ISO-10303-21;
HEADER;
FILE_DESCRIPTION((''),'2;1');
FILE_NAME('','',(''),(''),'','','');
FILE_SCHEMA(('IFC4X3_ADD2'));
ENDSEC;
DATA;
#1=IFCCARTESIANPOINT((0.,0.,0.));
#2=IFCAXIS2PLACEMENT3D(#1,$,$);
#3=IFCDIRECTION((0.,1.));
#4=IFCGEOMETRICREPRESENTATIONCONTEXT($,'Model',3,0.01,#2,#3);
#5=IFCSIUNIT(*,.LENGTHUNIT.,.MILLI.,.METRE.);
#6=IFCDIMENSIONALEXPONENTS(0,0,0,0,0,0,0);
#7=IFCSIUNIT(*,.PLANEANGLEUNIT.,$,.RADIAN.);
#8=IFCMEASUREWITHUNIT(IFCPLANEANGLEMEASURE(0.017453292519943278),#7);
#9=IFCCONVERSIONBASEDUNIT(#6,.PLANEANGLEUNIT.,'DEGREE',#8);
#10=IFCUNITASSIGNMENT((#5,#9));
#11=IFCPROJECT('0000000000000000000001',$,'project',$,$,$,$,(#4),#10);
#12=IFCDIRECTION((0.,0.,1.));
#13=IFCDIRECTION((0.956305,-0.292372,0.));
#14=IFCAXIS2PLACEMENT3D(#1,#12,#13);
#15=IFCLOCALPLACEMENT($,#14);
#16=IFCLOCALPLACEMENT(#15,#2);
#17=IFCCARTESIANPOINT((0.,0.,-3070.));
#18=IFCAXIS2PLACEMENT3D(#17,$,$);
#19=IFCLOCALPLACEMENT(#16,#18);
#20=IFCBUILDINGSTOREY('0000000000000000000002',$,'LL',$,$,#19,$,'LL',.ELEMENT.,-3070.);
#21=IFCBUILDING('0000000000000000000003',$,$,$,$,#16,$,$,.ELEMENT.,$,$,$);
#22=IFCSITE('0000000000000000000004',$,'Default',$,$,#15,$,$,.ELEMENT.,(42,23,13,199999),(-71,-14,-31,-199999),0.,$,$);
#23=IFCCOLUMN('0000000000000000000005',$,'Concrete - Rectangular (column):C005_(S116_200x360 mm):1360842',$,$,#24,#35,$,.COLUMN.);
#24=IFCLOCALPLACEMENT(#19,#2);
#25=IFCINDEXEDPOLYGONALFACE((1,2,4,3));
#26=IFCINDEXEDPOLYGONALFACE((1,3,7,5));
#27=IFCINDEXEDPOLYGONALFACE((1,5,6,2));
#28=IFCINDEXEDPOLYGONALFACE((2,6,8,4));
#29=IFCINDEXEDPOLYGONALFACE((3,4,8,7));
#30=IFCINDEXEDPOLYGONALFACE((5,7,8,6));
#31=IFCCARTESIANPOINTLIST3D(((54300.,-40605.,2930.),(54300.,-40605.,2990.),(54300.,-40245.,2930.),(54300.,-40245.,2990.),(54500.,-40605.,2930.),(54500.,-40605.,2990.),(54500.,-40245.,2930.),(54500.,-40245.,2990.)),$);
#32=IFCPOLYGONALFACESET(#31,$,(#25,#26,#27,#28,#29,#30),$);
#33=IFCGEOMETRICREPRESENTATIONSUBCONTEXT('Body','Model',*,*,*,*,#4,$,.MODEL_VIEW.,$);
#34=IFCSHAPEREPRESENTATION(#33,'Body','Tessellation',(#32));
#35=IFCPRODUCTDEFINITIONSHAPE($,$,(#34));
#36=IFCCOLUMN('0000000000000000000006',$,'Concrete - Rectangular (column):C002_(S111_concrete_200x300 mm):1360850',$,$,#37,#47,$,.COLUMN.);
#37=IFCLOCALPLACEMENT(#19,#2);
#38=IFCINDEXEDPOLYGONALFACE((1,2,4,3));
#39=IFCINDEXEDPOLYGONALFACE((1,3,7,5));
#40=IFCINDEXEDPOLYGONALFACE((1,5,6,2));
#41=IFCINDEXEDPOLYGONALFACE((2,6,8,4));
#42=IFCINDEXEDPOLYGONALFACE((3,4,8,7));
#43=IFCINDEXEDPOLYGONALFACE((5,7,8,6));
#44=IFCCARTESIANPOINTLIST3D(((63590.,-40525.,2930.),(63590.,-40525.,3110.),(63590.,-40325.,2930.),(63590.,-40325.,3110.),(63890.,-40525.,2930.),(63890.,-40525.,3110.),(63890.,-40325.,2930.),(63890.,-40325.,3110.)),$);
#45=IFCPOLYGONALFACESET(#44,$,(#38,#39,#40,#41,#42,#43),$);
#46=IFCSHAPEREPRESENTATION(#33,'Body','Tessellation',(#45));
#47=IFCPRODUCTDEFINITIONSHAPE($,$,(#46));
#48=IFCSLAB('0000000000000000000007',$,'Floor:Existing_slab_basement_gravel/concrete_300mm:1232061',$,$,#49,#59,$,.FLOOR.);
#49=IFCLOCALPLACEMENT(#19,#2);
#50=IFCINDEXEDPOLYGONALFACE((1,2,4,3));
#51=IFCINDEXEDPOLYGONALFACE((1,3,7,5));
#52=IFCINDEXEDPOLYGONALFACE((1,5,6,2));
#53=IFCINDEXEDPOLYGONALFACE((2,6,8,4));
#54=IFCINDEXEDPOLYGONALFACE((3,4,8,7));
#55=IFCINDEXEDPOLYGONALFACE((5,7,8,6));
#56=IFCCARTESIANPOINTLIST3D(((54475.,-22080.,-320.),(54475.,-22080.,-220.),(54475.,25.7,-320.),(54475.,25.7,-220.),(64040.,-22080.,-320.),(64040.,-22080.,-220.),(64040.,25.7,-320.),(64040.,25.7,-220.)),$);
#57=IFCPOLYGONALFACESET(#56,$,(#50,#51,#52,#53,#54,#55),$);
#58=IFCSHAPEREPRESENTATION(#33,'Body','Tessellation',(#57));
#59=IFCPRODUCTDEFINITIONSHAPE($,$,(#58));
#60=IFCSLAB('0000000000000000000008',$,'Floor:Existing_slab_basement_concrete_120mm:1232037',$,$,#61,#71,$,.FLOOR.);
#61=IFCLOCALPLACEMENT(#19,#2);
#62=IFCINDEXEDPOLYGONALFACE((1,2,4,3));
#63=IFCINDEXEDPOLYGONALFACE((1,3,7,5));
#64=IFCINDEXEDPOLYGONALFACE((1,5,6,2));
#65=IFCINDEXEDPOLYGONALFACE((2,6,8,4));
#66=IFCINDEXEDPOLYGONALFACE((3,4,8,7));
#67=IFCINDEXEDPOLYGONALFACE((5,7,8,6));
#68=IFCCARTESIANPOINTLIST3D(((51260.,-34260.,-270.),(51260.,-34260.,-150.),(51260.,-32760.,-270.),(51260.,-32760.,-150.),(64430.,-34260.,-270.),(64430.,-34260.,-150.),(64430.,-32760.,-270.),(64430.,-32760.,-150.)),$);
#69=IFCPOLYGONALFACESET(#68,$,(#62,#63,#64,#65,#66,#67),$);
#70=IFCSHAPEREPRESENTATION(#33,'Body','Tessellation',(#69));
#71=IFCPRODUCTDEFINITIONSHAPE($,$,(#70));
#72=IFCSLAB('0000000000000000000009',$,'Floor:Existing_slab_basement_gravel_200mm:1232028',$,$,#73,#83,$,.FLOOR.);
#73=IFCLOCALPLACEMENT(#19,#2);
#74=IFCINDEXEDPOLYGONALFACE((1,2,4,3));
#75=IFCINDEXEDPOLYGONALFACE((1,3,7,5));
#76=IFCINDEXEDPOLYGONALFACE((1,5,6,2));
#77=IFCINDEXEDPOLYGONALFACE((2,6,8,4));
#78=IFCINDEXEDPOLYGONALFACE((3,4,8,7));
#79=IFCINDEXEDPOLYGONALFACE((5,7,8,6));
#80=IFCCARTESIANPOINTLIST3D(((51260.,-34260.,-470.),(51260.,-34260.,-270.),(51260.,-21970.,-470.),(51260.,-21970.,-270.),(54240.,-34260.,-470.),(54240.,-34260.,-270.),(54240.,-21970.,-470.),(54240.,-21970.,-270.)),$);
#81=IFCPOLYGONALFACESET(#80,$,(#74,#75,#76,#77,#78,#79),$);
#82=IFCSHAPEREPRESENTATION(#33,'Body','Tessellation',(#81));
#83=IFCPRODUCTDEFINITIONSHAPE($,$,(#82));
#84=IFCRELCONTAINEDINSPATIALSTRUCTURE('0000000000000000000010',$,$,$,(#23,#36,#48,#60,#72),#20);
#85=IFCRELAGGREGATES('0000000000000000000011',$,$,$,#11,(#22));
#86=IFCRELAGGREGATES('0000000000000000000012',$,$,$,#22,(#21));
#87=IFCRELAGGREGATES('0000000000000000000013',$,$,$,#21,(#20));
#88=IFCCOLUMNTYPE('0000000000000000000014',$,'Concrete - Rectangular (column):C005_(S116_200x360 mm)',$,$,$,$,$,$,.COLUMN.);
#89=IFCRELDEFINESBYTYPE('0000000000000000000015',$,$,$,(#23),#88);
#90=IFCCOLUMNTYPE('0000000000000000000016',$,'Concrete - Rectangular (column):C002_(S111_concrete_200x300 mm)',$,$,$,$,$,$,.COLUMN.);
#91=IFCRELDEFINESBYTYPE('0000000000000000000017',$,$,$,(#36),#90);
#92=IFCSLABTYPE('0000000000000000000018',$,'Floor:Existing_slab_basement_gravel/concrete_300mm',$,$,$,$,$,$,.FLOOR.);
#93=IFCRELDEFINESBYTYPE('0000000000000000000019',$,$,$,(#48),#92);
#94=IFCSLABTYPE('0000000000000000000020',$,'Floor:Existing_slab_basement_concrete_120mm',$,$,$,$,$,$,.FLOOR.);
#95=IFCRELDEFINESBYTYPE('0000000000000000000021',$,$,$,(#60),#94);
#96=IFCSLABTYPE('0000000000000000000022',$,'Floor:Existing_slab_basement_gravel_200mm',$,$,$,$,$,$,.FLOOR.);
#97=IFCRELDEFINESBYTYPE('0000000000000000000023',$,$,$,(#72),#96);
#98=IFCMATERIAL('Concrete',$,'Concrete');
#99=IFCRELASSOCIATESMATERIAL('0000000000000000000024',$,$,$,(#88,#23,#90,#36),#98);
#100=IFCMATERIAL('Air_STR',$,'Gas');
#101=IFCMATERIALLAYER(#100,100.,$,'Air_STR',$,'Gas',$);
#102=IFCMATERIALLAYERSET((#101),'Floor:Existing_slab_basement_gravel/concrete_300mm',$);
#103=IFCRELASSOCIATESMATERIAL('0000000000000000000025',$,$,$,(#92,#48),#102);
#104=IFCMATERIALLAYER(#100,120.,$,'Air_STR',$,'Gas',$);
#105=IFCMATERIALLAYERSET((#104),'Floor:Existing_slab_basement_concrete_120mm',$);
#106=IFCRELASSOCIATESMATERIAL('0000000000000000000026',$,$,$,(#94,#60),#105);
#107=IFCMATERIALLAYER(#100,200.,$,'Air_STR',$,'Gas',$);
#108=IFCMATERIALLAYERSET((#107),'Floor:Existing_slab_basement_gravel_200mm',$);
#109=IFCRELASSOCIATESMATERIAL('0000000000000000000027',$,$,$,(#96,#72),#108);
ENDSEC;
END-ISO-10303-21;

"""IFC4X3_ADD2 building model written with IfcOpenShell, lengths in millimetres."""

from ifc_helpers import new_model, entity, si_unit, converted_unit, direction, frame, frame_2d, origin, place, context, subcontext, project, spatial, rectangle, extrude, source, transform, mapped, material, layer, layer_set, layer_usage, material_profile, profile_set, profile_usage, type_object, type_shapes, element, save


model = new_model("IFC4X3_ADD2")

# Units and contexts
model_context = context("Model", 3, precision=0.01, world=origin(), true_north=direction((0.0, 1.0)))
body_context = subcontext(model_context, "Body", "Model", "MODEL_VIEW")
ifc_project = project(units=[si_unit("LENGTHUNIT", "METRE", prefix="MILLI"), converted_unit("PLANEANGLEUNIT", "DEGREE", entity("IfcPlaneAngleMeasure", 0.017453292519943278), si_unit("PLANEANGLEUNIT", "RADIAN"), dimensions=[0, 0, 0, 0, 0, 0, 0])], contexts=[model_context])

# Site, building, storey
site_placement = place(None, frame((0.0, 0.0, 0.0), z_axis=(0.0, 0.0, 1.0), x_axis=(0.956305, -0.292372, 0.0)))
site = spatial("IfcSite", under=ifc_project, at=site_placement, Name="Default", CompositionType="ELEMENT", RefLatitude=(42, 23, 13, 199999), RefLongitude=(-71, -14, -31, -199999), RefElevation=0.0)
building_placement = place(site_placement, origin())
building = spatial("IfcBuilding", under=site, at=building_placement, CompositionType="ELEMENT")
storey_placement = place(building_placement, frame((0.0, 0.0, -3070.0)))
storey = spatial("IfcBuildingStorey", under=building, at=storey_placement, Name="LL", LongName="LL", CompositionType="ELEMENT", Elevation=-3070.0)

# Columns
ifc_material_1 = material(Name="Concrete", Category="Concrete")
ifc_material_profile_1 = material_profile(ifc_material_1, rectangle(XDim=300.0, YDim=200.0, at=frame_2d((0.0, 0.0), x_axis=(1.0, 0.0))), Name="C002_(S111_concrete_200x300 mm)")
ifc_profile_set_1 = profile_set([ifc_material_profile_1], Name="C002_(S111_concrete_200x300 mm)")
ifc_profile_usage_1 = profile_usage(ifc_profile_set_1)
ifc_material_profile_2 = material_profile(ifc_material_1, rectangle(XDim=200.0, YDim=360.0, at=frame_2d((0.0, 0.0), x_axis=(1.0, 0.0))), Name="C005_(S116_200x360 mm)")
ifc_profile_set_2 = profile_set([ifc_material_profile_2], Name="C005_(S116_200x360 mm)")
ifc_profile_usage_2 = profile_usage(ifc_profile_set_2)
column_type_1 = type_object("IfcColumnType", Name="Concrete - Rectangular (column):C005_(S116_200x360 mm)", PredefinedType="COLUMN", material=ifc_profile_set_2)
shared_shape_1 = source(origin(), body_context, "Body", "SweptSolid", [
    extrude(rectangle(XDim=200.0, YDim=360.0, at=frame_2d((0.0, 0.0), x_axis=(1.0, 0.0))), frame((54400.0, -40425.0, -140.0), z_axis=(0.0, 0.0, 1.0), x_axis=(-1.0, 0.0, 0.0)), (0.0, 0.0, 1.0), 60.0),
])
type_shapes(column_type_1, [shared_shape_1])
column_1_placement = place(storey_placement, frame((0.0, 0.0, 3070.0)))
element("IfcColumn", 1, at=column_1_placement, inside=storey, type_object=column_type_1, material=ifc_profile_usage_2, Name="Concrete - Rectangular (column):C005_(S116_200x360 mm):1360842", PredefinedType="COLUMN", context=body_context, shape_type="MappedRepresentation", body=[
    mapped(shared_shape_1, transform((0.0, 0.0, 0.0), scale=1.0)),
])
column_type_2 = type_object("IfcColumnType", Name="Concrete - Rectangular (column):C002_(S111_concrete_200x300 mm)", PredefinedType="COLUMN", material=ifc_profile_set_1)
shared_shape_2 = source(origin(), body_context, "Body", "SweptSolid", [
    extrude(rectangle(XDim=300.0, YDim=200.0, at=frame_2d((0.0, 0.0), x_axis=(1.0, 0.0))), frame((63740.0, -40425.0, -140.0), z_axis=(0.0, 0.0, 1.0), x_axis=(-1.0, 0.0, 0.0)), (0.0, 0.0, 1.0), 180.0),
])
type_shapes(column_type_2, [shared_shape_2])
column_2_placement = place(storey_placement, frame((0.0, 0.0, 3070.0)))
element("IfcColumn", 2, at=column_2_placement, inside=storey, type_object=column_type_2, material=ifc_profile_usage_1, Name="Concrete - Rectangular (column):C002_(S111_concrete_200x300 mm):1360850", PredefinedType="COLUMN", context=body_context, shape_type="MappedRepresentation", body=[
    mapped(shared_shape_2, transform((0.0, 0.0, 0.0), scale=1.0)),
])

# Slabs
ifc_material_2 = material(Name="Air_STR", Category="Gas")
ifc_layer_1 = layer(ifc_material_2, 100.0, Name="Air_STR", Category="Gas")
ifc_layer_set_1 = layer_set([ifc_layer_1], Name="Floor:Existing_slab_basement_gravel/concrete_300mm")
ifc_layer_usage_1 = layer_usage(ifc_layer_set_1, "AXIS3", "POSITIVE", 0.0)
slab_type_1 = type_object("IfcSlabType", Name="Floor:Existing_slab_basement_gravel/concrete_300mm", PredefinedType="FLOOR", material=ifc_layer_set_1)
slab_1_placement = place(storey_placement, origin())
element("IfcSlab", 3, at=slab_1_placement, inside=storey, type_object=slab_type_1, material=ifc_layer_usage_1, Name="Floor:Existing_slab_basement_gravel/concrete_300mm:1232061", PredefinedType="FLOOR", context=body_context, shape_type="SweptSolid", body=[
    extrude(rectangle(XDim=22105.7, YDim=9565.0, at=frame_2d((0.0, 0.0), x_axis=(1.0, 0.0))), frame((59257.5, -11027.1, -220.0), z_axis=(0.0, 0.0, -1.0), x_axis=(0.0, 1.0, 0.0)), (0.0, 0.0, 1.0), 100.0),
])
ifc_layer_2 = layer(ifc_material_2, 120.0, Name="Air_STR", Category="Gas")
ifc_layer_set_2 = layer_set([ifc_layer_2], Name="Floor:Existing_slab_basement_concrete_120mm")
ifc_layer_usage_2 = layer_usage(ifc_layer_set_2, "AXIS3", "POSITIVE", 0.0)
slab_type_2 = type_object("IfcSlabType", Name="Floor:Existing_slab_basement_concrete_120mm", PredefinedType="FLOOR", material=ifc_layer_set_2)
slab_2_placement = place(storey_placement, origin())
element("IfcSlab", 4, at=slab_2_placement, inside=storey, type_object=slab_type_2, material=ifc_layer_usage_2, Name="Floor:Existing_slab_basement_concrete_120mm:1232037", PredefinedType="FLOOR", context=body_context, shape_type="SweptSolid", body=[
    extrude(rectangle(XDim=1500.0, YDim=13170.0, at=frame_2d((0.0, 0.0), x_axis=(1.0, 0.0))), frame((57845.0, -33510.0, -150.0), z_axis=(0.0, 0.0, -1.0), x_axis=(0.0, 1.0, 0.0)), (0.0, 0.0, 1.0), 120.0),
])
ifc_layer_3 = layer(ifc_material_2, 200.0, Name="Air_STR", Category="Gas")
ifc_layer_set_3 = layer_set([ifc_layer_3], Name="Floor:Existing_slab_basement_gravel_200mm")
ifc_layer_usage_3 = layer_usage(ifc_layer_set_3, "AXIS3", "POSITIVE", 0.0)
slab_type_3 = type_object("IfcSlabType", Name="Floor:Existing_slab_basement_gravel_200mm", PredefinedType="FLOOR", material=ifc_layer_set_3)
slab_3_placement = place(storey_placement, origin())
element("IfcSlab", 5, at=slab_3_placement, inside=storey, type_object=slab_type_3, material=ifc_layer_usage_3, Name="Floor:Existing_slab_basement_gravel_200mm:1232028", PredefinedType="FLOOR", context=body_context, shape_type="SweptSolid", body=[
    extrude(rectangle(XDim=12290.0, YDim=2980.0, at=frame_2d((0.0, 0.0), x_axis=(1.0, 0.0))), frame((52750.0, -28115.0, -270.0), z_axis=(0.0, 0.0, -1.0), x_axis=(0.0, 1.0, 0.0)), (0.0, 0.0, 1.0), 200.0),
])

save(model, "model.ifc")
